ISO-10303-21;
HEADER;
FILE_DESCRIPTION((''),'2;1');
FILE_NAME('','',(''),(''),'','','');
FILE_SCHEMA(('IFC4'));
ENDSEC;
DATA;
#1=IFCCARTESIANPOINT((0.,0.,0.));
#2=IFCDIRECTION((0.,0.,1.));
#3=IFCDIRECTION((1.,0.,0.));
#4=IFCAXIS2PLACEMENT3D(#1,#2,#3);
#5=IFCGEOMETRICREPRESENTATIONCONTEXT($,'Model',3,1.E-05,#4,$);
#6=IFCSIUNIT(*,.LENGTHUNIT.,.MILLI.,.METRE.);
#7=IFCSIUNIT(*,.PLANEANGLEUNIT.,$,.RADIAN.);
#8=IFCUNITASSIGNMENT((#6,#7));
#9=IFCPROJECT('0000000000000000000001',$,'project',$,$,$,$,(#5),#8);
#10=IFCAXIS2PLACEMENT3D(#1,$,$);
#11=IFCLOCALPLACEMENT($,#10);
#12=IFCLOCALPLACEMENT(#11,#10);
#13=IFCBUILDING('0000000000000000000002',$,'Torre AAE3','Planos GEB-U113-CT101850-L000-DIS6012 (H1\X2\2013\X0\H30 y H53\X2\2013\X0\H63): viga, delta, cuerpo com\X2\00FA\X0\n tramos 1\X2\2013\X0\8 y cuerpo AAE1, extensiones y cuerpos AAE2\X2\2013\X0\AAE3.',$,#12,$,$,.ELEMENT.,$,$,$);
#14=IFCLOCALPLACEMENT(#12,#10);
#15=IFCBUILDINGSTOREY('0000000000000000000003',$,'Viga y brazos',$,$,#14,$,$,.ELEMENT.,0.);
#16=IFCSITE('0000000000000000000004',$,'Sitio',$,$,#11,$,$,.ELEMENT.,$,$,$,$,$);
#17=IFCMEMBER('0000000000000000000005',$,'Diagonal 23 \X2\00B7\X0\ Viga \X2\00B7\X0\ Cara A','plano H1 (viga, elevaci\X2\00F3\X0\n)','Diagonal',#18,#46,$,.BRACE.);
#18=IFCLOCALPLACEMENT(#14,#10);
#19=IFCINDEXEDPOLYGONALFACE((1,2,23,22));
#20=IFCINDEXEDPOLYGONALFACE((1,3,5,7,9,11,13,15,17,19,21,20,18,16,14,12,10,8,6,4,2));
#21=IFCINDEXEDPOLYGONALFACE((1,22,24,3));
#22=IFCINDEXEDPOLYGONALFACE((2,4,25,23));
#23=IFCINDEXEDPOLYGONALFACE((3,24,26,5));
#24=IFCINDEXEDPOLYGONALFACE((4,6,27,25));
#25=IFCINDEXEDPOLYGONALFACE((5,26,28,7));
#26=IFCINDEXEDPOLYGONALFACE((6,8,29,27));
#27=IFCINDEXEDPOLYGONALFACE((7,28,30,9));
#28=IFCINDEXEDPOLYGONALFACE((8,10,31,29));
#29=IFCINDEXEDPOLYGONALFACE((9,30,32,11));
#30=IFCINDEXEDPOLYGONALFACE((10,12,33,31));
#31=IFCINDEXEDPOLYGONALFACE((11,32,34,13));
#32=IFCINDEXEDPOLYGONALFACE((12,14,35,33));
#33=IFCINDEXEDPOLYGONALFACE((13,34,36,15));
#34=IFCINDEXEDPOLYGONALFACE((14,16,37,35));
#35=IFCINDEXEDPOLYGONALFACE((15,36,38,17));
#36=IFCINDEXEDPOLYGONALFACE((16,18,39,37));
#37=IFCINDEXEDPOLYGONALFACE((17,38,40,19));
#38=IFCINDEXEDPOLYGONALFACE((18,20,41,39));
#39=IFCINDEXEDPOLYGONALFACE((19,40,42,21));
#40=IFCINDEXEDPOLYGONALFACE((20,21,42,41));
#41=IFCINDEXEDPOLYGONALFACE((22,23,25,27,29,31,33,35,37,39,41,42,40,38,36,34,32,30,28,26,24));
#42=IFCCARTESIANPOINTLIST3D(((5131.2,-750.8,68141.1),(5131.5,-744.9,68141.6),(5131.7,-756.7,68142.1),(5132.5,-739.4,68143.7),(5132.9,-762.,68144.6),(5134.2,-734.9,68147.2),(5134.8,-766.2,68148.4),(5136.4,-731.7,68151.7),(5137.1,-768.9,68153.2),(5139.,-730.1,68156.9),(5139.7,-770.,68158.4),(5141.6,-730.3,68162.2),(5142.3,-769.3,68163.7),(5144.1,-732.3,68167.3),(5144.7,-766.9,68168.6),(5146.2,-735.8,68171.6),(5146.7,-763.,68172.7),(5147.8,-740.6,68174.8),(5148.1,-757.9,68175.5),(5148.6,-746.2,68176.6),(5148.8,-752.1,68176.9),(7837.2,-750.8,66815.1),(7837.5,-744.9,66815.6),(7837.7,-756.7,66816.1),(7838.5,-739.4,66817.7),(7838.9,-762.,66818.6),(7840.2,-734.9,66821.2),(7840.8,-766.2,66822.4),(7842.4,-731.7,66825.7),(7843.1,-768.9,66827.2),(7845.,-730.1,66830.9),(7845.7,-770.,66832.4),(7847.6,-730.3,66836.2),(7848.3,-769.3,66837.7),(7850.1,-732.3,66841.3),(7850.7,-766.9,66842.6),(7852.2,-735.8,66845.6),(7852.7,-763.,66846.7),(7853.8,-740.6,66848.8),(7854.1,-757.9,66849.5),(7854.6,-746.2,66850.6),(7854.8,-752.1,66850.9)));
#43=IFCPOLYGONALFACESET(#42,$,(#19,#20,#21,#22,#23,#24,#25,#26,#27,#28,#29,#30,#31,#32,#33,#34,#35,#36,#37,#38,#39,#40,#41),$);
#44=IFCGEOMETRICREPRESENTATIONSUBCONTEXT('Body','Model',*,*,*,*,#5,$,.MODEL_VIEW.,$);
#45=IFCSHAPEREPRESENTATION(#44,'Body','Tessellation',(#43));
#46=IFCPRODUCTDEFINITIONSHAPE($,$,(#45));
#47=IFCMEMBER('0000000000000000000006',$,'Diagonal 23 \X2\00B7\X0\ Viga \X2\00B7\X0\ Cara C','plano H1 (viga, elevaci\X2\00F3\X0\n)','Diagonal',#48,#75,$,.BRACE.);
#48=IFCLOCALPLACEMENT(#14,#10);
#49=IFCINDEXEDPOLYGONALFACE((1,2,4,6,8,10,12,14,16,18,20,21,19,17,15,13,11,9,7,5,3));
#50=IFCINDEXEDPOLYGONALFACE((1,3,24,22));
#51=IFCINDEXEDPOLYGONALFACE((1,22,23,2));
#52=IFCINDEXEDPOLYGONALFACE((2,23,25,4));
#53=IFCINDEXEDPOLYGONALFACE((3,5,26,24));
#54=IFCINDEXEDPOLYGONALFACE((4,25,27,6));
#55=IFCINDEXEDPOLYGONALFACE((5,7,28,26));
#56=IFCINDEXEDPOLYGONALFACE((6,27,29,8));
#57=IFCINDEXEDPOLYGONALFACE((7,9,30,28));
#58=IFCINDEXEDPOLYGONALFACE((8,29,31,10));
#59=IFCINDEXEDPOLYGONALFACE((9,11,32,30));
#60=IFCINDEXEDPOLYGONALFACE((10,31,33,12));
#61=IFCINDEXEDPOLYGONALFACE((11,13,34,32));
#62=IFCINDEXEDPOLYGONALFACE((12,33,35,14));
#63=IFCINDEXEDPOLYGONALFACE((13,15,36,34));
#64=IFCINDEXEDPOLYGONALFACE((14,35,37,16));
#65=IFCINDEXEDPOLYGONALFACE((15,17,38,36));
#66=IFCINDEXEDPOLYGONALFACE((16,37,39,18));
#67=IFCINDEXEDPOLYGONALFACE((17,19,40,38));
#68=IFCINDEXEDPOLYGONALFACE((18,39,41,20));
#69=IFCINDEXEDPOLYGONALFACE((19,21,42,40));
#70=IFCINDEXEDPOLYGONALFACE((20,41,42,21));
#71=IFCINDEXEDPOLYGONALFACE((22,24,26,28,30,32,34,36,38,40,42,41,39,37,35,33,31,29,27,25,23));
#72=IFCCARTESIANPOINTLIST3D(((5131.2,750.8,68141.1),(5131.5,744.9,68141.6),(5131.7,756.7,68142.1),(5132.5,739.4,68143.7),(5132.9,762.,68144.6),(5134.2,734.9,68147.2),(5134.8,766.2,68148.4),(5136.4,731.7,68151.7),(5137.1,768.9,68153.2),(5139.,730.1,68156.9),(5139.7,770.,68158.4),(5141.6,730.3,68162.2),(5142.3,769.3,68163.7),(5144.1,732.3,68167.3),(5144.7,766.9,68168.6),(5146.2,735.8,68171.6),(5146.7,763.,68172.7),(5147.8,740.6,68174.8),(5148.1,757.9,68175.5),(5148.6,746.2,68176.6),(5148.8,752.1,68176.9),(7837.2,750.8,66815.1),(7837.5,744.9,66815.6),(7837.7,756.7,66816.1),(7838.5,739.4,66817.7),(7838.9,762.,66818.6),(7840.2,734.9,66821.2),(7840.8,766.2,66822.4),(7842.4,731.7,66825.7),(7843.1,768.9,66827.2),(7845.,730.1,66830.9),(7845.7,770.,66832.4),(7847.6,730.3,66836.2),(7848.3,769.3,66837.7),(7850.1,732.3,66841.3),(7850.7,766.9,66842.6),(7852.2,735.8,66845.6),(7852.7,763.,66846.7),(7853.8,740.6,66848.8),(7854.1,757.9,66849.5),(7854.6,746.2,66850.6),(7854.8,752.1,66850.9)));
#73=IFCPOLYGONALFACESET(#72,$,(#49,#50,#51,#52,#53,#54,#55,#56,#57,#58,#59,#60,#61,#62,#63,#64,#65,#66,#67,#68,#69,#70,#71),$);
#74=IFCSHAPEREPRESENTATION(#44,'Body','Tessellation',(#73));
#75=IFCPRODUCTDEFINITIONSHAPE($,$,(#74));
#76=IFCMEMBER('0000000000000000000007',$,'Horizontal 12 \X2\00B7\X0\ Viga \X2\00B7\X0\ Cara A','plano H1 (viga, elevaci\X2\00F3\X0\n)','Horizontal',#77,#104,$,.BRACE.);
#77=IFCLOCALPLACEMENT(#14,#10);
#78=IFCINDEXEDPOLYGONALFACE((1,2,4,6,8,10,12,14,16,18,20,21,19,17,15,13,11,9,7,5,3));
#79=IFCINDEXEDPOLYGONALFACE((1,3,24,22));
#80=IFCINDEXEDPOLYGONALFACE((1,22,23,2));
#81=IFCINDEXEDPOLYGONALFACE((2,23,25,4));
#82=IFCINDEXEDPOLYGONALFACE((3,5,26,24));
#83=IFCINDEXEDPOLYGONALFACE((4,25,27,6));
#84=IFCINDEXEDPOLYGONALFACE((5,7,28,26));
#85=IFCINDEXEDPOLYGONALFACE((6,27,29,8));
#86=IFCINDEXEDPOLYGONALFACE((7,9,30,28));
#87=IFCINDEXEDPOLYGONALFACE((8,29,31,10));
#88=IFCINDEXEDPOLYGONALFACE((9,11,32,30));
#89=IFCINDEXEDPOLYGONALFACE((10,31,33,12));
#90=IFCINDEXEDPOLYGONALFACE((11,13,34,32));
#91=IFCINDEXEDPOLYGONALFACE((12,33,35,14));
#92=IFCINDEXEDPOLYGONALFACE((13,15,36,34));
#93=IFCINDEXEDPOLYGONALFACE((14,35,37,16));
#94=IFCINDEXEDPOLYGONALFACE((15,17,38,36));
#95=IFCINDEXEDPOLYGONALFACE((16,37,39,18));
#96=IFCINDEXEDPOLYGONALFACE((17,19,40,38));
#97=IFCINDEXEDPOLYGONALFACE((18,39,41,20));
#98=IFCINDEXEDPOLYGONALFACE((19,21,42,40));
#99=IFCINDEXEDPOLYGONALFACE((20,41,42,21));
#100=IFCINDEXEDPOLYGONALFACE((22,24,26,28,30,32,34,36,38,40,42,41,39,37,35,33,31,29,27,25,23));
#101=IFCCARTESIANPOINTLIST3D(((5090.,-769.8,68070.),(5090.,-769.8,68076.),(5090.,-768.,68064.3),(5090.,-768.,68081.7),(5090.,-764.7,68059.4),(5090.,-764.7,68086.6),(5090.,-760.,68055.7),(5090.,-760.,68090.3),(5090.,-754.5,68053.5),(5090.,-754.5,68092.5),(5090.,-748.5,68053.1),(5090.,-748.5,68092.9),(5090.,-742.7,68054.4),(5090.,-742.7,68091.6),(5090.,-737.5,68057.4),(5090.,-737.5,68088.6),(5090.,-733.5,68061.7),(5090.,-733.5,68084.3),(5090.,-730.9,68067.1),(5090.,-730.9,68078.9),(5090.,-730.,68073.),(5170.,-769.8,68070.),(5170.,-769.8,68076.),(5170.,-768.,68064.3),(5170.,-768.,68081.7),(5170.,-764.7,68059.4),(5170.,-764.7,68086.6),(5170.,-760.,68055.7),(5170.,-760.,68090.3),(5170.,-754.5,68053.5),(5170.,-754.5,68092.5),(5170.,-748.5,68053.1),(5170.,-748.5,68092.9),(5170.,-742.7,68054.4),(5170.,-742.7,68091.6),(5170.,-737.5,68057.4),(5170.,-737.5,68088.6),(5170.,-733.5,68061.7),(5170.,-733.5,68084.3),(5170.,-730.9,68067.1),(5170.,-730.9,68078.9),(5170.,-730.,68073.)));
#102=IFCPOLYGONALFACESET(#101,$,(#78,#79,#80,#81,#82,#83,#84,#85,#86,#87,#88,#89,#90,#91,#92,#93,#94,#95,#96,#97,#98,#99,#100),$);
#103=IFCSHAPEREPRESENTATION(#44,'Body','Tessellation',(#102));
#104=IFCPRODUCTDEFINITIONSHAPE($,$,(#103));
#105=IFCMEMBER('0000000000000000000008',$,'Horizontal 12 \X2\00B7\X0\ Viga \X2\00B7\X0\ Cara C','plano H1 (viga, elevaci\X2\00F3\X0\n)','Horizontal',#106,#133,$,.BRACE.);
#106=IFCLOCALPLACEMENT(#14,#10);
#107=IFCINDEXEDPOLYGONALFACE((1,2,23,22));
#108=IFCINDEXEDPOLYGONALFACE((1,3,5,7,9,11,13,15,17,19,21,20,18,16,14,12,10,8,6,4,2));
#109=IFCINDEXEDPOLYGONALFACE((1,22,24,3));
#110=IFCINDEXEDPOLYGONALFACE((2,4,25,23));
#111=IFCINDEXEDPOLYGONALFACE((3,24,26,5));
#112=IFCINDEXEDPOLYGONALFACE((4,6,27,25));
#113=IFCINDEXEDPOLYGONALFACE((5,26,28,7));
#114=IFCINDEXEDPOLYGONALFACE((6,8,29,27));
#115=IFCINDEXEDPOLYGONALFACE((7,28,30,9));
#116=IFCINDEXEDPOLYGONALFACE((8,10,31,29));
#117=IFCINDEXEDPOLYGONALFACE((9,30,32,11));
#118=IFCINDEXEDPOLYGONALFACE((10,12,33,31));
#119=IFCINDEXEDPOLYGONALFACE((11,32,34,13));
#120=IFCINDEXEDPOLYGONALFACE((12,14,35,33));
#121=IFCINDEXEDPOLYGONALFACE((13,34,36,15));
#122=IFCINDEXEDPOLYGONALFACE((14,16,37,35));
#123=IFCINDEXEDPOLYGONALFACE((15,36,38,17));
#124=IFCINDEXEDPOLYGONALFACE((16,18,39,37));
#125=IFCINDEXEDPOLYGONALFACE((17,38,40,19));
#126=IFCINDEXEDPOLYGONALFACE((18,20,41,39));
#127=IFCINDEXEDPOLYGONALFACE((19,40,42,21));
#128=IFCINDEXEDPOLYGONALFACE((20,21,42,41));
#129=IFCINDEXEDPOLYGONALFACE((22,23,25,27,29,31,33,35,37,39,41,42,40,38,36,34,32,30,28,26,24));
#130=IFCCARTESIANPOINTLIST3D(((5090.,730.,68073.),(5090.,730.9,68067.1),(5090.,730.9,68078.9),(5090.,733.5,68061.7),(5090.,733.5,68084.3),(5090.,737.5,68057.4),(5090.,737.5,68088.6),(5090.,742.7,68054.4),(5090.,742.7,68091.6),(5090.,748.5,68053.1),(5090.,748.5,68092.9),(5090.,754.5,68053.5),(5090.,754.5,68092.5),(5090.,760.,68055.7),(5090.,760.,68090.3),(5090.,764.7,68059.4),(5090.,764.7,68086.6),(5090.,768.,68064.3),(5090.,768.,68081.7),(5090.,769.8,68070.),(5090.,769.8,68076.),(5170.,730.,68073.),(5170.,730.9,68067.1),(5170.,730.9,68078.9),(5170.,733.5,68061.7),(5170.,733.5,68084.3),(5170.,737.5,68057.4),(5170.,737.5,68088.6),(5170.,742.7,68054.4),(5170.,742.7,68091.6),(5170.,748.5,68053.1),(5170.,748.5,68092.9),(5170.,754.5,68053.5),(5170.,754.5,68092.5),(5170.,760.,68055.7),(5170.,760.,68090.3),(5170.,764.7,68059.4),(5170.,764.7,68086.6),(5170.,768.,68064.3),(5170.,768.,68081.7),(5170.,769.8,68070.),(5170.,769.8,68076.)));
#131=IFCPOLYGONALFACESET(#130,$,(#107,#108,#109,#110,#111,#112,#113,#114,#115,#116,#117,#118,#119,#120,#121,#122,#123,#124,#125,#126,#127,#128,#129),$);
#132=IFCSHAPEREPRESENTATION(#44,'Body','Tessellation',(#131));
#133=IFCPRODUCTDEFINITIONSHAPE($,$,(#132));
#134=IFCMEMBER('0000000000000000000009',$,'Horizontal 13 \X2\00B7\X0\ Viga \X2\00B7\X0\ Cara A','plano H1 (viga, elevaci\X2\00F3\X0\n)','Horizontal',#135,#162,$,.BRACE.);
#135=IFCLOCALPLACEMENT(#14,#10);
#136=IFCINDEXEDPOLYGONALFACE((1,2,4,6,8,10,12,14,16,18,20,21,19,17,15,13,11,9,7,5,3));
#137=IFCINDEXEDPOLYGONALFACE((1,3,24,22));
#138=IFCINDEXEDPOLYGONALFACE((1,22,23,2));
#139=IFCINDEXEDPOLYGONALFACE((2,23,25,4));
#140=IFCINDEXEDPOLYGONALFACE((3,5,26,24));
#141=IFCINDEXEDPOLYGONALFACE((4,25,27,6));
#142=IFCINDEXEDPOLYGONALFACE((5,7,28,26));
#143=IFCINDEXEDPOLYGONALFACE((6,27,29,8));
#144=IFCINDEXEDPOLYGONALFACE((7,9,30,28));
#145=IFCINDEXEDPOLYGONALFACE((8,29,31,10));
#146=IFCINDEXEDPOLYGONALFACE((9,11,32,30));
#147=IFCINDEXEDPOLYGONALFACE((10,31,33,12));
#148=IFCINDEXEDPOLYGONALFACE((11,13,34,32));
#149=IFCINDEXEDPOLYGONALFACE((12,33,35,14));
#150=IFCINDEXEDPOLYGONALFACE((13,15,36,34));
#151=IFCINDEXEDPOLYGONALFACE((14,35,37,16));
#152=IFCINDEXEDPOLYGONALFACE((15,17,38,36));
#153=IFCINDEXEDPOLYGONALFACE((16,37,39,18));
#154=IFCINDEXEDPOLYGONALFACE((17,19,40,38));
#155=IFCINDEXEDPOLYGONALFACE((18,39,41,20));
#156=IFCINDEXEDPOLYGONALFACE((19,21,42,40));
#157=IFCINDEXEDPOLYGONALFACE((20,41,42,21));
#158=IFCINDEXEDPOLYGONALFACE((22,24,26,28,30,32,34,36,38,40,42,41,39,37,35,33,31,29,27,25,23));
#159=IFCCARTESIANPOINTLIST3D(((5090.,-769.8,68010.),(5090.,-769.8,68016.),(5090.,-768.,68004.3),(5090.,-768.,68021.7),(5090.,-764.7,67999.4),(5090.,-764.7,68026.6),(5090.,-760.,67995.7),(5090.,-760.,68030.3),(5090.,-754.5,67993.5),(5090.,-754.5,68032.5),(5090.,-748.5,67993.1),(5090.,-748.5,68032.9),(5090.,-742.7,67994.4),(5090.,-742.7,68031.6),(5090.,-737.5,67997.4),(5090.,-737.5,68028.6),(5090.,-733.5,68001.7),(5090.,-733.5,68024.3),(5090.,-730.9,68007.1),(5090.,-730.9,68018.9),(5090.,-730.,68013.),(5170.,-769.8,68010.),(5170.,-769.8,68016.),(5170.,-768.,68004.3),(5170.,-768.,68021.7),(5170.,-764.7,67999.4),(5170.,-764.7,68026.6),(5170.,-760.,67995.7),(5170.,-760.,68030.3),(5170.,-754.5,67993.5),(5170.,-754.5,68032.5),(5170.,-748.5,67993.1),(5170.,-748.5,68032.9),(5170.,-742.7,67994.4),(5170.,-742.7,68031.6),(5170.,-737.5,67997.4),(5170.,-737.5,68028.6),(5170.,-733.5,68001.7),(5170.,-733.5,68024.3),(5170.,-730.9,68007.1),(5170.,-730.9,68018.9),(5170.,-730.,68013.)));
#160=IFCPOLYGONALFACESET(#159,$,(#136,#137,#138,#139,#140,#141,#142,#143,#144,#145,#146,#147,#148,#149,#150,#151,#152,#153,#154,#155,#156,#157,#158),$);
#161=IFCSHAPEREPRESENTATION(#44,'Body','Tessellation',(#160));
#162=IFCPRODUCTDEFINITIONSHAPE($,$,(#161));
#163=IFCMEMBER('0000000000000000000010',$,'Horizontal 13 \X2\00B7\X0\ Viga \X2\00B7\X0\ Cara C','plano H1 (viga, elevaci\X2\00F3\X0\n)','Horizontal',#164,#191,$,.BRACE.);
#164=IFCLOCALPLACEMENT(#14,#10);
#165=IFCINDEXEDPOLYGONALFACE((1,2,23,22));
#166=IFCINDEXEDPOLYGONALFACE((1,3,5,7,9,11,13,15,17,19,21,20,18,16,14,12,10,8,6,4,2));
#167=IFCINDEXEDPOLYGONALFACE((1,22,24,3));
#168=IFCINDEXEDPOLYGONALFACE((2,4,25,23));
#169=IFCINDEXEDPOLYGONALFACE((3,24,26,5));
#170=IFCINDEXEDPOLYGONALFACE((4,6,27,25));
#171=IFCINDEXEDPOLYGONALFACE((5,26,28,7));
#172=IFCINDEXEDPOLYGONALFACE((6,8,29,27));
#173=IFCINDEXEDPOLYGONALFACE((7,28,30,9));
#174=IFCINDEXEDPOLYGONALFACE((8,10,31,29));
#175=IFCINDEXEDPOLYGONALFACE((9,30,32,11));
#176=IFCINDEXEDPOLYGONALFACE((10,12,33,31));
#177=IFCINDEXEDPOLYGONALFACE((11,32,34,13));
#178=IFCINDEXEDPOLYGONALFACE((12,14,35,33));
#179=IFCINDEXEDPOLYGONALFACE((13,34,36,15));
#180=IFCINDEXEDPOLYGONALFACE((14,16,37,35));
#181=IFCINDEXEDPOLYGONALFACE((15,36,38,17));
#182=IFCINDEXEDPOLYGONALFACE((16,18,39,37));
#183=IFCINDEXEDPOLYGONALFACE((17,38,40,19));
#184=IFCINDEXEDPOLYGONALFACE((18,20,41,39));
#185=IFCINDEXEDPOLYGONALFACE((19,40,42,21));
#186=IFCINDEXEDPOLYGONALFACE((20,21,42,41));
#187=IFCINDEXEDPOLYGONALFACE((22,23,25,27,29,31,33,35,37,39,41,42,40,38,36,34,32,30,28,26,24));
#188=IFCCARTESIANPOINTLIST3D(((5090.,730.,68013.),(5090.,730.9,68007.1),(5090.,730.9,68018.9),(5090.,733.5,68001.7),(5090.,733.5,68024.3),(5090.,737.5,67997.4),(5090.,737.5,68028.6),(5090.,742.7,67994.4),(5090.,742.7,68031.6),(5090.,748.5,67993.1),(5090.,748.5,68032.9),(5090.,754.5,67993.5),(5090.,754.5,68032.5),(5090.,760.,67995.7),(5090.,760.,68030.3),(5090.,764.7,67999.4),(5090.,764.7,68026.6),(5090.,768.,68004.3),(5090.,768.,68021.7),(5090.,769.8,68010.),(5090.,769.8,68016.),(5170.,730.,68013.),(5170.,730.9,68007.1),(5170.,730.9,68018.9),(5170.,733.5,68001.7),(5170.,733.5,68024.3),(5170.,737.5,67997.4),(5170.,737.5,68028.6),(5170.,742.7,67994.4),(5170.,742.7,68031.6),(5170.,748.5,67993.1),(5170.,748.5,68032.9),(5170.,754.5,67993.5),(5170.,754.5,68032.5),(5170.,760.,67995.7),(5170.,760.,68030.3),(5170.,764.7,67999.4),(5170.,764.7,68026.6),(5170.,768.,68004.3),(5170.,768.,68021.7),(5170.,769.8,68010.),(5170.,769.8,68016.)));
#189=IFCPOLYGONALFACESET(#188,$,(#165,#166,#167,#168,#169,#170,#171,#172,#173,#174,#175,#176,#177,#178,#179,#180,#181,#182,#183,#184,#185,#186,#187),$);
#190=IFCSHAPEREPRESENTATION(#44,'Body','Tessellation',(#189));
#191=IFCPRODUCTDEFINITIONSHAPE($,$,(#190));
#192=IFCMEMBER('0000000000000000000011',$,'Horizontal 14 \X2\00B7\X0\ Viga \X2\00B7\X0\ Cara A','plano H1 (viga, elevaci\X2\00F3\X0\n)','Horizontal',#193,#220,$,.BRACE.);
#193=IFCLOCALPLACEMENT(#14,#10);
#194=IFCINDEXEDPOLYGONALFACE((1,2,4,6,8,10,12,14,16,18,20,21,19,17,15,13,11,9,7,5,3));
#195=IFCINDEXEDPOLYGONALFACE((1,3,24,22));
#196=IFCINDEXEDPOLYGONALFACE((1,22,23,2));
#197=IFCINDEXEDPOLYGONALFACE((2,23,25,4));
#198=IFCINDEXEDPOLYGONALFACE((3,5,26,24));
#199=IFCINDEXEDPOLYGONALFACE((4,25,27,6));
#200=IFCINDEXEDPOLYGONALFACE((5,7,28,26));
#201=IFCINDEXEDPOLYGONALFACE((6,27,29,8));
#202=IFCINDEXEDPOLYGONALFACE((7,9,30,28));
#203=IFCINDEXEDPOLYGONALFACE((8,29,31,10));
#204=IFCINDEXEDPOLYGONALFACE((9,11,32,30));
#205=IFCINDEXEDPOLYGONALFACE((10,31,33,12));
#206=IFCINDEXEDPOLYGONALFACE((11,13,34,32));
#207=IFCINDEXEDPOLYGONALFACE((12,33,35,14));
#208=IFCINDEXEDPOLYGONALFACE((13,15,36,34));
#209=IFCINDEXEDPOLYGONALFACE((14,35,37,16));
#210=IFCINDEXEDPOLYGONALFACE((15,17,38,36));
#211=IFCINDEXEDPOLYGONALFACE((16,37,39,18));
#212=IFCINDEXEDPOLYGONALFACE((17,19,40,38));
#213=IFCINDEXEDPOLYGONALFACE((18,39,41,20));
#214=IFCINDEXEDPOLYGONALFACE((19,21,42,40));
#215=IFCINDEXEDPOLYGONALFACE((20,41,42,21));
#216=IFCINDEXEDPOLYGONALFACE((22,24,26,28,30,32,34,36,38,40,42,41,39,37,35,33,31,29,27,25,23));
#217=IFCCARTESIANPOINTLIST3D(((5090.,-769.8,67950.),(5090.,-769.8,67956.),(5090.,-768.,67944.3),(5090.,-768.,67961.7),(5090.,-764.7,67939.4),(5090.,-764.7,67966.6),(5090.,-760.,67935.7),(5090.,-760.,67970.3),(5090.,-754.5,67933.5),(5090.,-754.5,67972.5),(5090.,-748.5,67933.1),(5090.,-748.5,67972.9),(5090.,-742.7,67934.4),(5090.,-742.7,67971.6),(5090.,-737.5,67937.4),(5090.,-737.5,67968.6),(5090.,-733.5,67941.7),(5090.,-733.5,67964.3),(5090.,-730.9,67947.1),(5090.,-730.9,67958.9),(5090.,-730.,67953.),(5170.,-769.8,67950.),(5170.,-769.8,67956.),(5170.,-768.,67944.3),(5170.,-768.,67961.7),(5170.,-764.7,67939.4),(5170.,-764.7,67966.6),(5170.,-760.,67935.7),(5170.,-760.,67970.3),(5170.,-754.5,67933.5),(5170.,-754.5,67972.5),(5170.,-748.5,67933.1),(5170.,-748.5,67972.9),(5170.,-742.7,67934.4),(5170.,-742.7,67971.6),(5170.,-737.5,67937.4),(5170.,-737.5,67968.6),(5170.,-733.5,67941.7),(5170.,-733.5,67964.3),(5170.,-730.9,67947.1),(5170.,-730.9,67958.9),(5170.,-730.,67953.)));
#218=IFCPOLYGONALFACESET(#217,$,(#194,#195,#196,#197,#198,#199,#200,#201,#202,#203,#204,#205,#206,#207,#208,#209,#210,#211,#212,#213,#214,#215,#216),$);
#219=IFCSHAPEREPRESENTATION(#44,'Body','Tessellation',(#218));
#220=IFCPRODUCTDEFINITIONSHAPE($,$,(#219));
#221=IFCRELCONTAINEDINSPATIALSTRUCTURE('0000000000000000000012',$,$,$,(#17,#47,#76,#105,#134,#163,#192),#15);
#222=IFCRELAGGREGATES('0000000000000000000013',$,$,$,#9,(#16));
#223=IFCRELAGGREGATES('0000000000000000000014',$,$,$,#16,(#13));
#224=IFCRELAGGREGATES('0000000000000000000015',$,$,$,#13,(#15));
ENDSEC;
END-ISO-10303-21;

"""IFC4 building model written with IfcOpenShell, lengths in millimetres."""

from ifc_helpers import new_model, si_unit, frame, origin, origin_with_axes, place, context, subcontext, project, spatial, circle, extrude, element, save


model = new_model("IFC4")

# Units and contexts
model_context = context("Model", 3, precision=1e-05, world=origin_with_axes())
body_context = subcontext(model_context, "Body", "Model", "MODEL_VIEW")
ifc_project = project(units=[si_unit("LENGTHUNIT", "METRE", prefix="MILLI"), si_unit("PLANEANGLEUNIT", "RADIAN")], contexts=[model_context])

# Site, building, storey
site_placement = place(None, origin())
site = spatial("IfcSite", under=ifc_project, at=site_placement, Name="Sitio", CompositionType="ELEMENT")
building_placement = place(site_placement, origin())
building = spatial("IfcBuilding", under=site, at=building_placement, Name="Torre AAE3", Description="Planos GEB-U113-CT101850-L000-DIS6012 (H1–H30 y H53–H63): viga, delta, cuerpo común tramos 1–8 y cuerpo AAE1, extensiones y cuerpos AAE2–AAE3.", CompositionType="ELEMENT")
storey_placement = place(building_placement, origin())
storey = spatial("IfcBuildingStorey", under=building, at=storey_placement, Name="Viga y brazos", CompositionType="ELEMENT", Elevation=0.0)

# Members
for number, where, z_axis, x_axis, name in (
    (1, (5140.0, -750.0, 68159.0), (0.897982, 0.0, -0.440031), (-0.425612, 0.2539, -0.868556), "Diagonal 23 · Viga · Cara A"),
    (2, (5140.0, 750.0, 68159.0), (0.897982, 0.0, -0.440031), (-0.425612, -0.2539, -0.868556), "Diagonal 23 · Viga · Cara C"),
):
    element("IfcMember", number, at=place(storey_placement, frame(where, z_axis=z_axis, x_axis=x_axis)), inside=storey, Name=name, Description="plano H1 (viga, elevación)", ObjectType="Diagonal", PredefinedType="BRACE", context=body_context, shape_type="SweptSolid", body=[
        extrude(circle(Radius=20.0), None, (0.0, 0.0, 1.0), 3013.4),
    ])
for number, where, z_axis, x_axis, name in (
    (3, (5090.0, -750.0, 68073.0), (1.0, 0.0, 0.0), (0.0, 1.0, 0.0), "Horizontal 12 · Viga · Cara A"),
    (4, (5090.0, 750.0, 68073.0), (1.0, 0.0, 0.0), (0.0, -1.0, 0.0), "Horizontal 12 · Viga · Cara C"),
    (5, (5090.0, -750.0, 68013.0), (1.0, 0.0, 0.0), (0.0, 1.0, 0.0), "Horizontal 13 · Viga · Cara A"),
    (6, (5090.0, 750.0, 68013.0), (1.0, 0.0, 0.0), (0.0, -1.0, 0.0), "Horizontal 13 · Viga · Cara C"),
    (7, (5090.0, -750.0, 67953.0), (1.0, 0.0, 0.0), (0.0, 1.0, 0.0), "Horizontal 14 · Viga · Cara A"),
):
    element("IfcMember", number, at=place(storey_placement, frame(where, z_axis=z_axis, x_axis=x_axis)), inside=storey, Name=name, Description="plano H1 (viga, elevación)", ObjectType="Horizontal", PredefinedType="BRACE", context=body_context, shape_type="SweptSolid", body=[
        extrude(circle(Radius=20.0), None, (0.0, 0.0, 1.0), 80.0),
    ])

save(model, "model.ifc")
